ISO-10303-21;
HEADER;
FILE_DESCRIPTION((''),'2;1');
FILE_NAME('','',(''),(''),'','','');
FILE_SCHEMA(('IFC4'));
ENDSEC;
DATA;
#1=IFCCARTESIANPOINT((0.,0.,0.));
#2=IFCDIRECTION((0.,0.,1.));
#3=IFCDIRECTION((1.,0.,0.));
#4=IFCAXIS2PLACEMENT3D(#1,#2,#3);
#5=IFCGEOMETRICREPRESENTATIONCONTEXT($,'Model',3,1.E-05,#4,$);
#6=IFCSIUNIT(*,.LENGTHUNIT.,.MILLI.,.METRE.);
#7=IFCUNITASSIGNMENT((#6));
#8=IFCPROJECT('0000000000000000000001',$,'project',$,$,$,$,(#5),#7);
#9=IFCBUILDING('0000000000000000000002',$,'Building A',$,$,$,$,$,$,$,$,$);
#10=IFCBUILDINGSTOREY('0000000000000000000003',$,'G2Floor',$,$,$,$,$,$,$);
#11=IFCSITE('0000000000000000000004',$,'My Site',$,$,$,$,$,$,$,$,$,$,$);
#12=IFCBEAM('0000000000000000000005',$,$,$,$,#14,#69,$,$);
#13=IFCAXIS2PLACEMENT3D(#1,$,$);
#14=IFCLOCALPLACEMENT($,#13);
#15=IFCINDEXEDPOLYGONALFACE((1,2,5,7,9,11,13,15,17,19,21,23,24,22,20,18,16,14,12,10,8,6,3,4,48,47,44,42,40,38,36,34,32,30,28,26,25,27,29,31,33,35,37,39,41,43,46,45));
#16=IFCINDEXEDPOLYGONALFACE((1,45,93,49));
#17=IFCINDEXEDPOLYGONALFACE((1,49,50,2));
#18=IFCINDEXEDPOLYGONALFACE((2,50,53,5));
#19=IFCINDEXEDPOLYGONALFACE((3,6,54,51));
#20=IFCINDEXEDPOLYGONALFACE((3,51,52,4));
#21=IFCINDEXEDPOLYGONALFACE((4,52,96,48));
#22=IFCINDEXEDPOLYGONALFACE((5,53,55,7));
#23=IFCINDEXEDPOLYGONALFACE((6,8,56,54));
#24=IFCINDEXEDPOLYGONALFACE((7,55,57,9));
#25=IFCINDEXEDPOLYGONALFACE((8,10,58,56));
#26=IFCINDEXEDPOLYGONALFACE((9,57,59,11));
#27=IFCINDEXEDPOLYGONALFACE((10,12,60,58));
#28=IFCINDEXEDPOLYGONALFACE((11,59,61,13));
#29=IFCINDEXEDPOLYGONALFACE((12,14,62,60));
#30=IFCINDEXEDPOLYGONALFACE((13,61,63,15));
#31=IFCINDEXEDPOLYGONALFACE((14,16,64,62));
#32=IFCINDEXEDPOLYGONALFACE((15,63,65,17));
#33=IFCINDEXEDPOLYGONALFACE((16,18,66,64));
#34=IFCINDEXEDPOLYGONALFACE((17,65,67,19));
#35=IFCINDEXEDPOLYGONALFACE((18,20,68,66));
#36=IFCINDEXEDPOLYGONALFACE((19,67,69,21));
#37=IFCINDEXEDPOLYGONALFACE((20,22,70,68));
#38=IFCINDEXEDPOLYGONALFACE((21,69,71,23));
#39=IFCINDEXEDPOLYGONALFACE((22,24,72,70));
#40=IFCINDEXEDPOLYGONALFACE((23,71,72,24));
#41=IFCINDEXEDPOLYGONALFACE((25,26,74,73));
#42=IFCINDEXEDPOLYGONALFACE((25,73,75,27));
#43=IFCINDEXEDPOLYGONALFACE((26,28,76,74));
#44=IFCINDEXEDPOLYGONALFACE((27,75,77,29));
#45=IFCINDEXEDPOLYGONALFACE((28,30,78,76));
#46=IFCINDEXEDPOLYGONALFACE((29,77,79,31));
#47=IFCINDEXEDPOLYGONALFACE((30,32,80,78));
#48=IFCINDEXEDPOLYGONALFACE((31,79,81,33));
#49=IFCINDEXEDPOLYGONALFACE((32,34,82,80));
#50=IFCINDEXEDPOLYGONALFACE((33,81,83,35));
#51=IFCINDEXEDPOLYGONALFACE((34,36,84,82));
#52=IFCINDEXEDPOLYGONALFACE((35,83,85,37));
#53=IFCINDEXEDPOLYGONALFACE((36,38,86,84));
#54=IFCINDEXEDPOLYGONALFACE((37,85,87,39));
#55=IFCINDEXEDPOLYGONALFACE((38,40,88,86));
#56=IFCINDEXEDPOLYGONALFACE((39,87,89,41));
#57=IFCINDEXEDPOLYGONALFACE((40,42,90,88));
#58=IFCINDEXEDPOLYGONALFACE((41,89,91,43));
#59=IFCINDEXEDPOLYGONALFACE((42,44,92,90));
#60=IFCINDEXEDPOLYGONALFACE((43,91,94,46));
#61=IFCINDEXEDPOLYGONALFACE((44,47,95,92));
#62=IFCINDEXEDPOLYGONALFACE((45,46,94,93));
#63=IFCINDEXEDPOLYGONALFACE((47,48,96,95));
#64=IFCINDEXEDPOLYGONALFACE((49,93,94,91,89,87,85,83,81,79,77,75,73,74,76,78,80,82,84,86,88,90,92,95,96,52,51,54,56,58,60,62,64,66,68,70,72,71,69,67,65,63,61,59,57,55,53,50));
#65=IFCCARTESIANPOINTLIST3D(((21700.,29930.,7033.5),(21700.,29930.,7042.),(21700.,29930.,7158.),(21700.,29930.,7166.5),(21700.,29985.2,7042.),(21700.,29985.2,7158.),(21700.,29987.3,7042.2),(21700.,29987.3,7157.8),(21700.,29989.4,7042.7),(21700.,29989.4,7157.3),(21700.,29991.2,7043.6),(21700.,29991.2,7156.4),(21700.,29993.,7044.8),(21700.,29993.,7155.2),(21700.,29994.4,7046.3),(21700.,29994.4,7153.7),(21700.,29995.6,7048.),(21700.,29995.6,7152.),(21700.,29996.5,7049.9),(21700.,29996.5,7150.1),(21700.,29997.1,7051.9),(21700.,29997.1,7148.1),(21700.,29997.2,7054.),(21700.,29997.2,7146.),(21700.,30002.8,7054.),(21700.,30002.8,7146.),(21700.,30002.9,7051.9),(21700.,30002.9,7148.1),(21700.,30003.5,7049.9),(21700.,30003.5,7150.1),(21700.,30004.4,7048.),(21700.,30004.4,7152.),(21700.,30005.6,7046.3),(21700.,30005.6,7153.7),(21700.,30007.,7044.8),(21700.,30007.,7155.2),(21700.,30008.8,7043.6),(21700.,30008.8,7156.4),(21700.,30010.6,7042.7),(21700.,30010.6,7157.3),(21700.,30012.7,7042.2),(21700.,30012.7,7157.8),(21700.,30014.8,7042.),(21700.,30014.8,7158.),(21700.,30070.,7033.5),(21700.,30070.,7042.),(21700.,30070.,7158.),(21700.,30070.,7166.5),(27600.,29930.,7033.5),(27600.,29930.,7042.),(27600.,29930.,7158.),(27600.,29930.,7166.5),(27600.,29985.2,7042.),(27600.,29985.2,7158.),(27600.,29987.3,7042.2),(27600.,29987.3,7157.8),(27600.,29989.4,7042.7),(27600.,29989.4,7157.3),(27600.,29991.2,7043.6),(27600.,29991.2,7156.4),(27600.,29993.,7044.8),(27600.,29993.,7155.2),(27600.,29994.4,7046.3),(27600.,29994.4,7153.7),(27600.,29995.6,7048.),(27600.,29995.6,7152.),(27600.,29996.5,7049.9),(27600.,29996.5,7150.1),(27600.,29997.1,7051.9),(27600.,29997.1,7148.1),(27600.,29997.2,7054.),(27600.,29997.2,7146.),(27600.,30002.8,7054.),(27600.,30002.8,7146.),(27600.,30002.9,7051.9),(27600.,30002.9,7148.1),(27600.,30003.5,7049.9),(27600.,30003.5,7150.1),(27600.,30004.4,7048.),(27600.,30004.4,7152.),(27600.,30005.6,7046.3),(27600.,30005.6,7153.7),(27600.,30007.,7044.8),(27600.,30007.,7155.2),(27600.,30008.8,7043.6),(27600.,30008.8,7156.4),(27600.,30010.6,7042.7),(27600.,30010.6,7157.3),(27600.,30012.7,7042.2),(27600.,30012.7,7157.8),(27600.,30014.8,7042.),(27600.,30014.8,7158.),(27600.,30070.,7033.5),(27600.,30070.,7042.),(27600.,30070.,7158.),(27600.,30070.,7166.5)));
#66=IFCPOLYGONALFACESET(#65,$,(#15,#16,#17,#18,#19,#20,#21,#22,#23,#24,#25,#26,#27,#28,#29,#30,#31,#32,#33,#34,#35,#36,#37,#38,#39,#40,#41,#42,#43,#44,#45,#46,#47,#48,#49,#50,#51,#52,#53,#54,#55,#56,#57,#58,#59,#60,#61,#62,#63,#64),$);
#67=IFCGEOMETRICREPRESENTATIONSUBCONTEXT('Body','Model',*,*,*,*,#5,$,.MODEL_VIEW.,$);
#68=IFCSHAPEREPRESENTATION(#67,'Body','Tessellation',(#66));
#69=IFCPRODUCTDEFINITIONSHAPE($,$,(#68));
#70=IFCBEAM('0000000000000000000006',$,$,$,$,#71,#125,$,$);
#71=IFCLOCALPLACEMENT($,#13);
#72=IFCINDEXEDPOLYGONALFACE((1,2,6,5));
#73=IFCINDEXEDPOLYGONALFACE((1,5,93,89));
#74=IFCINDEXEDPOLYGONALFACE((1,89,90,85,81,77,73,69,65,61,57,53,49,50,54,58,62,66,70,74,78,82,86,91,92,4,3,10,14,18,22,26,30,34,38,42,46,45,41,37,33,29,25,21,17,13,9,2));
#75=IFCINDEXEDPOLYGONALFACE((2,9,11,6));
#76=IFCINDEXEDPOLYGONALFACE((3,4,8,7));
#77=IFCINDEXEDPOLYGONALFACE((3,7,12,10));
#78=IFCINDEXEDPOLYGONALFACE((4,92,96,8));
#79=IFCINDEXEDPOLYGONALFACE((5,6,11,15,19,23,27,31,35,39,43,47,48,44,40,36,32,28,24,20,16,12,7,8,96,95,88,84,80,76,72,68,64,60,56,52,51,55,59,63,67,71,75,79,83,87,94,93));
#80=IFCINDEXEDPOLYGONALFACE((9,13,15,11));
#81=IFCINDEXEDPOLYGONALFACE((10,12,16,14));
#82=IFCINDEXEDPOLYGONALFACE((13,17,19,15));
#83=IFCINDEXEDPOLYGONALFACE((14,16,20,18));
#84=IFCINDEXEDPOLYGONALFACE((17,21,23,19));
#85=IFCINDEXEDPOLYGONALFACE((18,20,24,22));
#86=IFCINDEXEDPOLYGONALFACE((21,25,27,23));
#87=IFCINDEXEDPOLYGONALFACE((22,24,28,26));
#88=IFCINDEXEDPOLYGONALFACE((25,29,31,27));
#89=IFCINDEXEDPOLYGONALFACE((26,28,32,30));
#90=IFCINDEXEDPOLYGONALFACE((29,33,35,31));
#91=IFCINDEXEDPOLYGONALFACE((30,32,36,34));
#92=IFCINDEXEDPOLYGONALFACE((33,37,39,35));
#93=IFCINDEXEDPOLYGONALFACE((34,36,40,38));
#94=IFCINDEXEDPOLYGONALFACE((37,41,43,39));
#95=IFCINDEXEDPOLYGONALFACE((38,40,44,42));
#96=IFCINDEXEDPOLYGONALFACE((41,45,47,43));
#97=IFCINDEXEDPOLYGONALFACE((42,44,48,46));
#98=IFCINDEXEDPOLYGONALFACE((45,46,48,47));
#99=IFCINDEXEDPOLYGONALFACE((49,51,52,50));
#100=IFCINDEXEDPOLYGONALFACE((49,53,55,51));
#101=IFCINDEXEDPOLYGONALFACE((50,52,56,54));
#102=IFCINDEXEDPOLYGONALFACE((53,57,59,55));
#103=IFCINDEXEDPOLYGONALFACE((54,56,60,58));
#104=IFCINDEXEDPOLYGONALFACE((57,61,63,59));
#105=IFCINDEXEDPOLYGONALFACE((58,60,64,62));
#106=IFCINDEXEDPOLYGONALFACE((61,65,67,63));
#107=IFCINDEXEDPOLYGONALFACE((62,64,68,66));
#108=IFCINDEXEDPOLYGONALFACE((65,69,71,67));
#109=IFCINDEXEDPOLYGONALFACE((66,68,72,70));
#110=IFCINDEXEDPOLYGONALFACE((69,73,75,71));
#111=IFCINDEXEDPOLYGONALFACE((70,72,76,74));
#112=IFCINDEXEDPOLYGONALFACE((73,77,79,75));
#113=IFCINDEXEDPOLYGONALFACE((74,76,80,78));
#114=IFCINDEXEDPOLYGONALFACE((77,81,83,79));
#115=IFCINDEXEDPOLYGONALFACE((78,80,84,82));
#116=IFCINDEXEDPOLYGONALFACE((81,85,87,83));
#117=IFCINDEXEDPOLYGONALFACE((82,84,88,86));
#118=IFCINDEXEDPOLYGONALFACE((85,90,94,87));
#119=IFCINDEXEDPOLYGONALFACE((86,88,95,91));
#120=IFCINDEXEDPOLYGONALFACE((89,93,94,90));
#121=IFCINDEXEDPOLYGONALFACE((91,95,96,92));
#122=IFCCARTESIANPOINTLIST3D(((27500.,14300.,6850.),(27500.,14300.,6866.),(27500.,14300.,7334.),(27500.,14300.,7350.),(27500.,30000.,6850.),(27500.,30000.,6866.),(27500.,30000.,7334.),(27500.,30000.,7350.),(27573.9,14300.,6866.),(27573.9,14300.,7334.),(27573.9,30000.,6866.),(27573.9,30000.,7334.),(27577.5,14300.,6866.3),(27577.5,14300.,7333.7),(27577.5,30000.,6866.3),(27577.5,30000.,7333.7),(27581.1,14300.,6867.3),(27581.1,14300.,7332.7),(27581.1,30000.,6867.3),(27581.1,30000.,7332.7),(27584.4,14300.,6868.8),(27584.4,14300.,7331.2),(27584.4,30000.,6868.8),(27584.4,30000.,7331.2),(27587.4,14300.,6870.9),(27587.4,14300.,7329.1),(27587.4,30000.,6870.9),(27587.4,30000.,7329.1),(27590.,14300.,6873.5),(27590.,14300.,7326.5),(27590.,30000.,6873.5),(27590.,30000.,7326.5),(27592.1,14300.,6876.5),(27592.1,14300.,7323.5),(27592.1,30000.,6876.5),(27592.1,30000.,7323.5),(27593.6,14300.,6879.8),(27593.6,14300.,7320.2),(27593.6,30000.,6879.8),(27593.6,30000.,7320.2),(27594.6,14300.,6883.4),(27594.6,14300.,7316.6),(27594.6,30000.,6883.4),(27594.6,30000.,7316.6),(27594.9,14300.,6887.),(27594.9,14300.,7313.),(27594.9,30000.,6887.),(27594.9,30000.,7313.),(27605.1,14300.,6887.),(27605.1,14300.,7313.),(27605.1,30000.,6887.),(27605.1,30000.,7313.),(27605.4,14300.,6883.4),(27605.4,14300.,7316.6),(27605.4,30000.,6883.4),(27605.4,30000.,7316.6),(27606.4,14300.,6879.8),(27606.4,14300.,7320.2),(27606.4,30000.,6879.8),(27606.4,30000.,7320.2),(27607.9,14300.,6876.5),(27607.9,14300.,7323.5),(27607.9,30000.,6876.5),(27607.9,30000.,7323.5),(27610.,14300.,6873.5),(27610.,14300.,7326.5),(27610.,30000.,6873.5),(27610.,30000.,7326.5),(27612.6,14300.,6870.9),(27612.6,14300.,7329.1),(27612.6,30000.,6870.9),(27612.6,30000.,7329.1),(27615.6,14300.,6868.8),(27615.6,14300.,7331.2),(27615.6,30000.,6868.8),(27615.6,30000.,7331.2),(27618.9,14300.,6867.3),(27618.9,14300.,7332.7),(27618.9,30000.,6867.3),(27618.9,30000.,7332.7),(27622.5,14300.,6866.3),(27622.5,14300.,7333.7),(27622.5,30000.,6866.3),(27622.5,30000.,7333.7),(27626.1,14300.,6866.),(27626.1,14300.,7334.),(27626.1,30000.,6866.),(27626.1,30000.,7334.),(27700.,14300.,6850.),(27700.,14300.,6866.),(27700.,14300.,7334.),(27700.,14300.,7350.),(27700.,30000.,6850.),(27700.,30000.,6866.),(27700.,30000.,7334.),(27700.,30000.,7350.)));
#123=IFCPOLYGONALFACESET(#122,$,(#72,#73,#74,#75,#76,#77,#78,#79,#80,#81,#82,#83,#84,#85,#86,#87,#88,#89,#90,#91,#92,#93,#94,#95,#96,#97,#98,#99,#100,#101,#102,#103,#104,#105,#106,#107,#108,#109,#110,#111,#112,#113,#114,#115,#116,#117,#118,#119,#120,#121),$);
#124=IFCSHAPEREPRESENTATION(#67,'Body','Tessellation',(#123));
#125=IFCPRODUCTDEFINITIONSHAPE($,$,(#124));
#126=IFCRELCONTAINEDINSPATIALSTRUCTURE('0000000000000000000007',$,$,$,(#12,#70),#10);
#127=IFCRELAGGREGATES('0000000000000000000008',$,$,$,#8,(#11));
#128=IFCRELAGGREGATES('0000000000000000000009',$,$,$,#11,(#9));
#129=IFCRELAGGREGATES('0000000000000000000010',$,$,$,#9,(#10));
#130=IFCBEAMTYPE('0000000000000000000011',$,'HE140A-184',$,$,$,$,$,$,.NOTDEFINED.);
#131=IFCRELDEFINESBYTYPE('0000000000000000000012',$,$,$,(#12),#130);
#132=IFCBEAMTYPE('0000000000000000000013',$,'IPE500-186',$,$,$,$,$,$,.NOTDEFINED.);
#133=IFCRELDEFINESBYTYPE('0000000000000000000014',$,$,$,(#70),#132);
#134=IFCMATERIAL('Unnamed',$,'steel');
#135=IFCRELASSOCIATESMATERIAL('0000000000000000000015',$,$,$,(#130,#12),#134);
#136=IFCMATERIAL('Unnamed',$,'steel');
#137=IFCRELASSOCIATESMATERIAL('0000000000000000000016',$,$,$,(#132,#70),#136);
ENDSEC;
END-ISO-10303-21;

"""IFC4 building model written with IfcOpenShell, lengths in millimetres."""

from ifc_helpers import new_model, si_unit, frame, origin_with_axes, place, context, subcontext, project, spatial, polyline, outline, extrude, material, material_profile, profile_set, profile_usage, type_object, element, save


model = new_model("IFC4")

# Units and contexts
model_context = context("Model", 3, precision=1e-05, world=origin_with_axes())
body_context = subcontext(model_context, "Body", "Model", "MODEL_VIEW")
ifc_project = project(units=[si_unit("LENGTHUNIT", "METRE", prefix="MILLI")], contexts=[model_context])

# Site, building, storey
site = spatial("IfcSite", under=ifc_project, Name="My Site")
building = spatial("IfcBuilding", under=site, Name="Building A")
storey = spatial("IfcBuildingStorey", under=building, Name="G2Floor")

# Beams
ifc_material_1 = material(Name="Unnamed", Category="steel")
ifc_material_profile_1 = material_profile(ifc_material_1, outline(polyline([(70.0, -66.5), (70.0, -58.0), (70.0, -58.0), (14.8, -58.0), (14.8, -58.0), (12.7, -57.8), (12.7, -57.8), (10.6, -57.3), (10.6, -57.3), (8.8, -56.4), (8.8, -56.4), (7.0, -55.2), (7.0, -55.2), (5.6, -53.7), (5.6, -53.7), (4.4, -52.0), (4.4, -52.0), (3.5, -50.1), (3.5, -50.1), (2.9, -48.1), (2.9, -48.1), (2.8, -46.0), (2.8, -46.0), (2.8, 46.0), (2.8, 46.0), (2.9, 48.1), (2.9, 48.1), (3.5, 50.1), (3.5, 50.1), (4.4, 52.0), (4.4, 52.0), (5.6, 53.7), (5.6, 53.7), (7.0, 55.2), (7.0, 55.2), (8.8, 56.4), (8.8, 56.4), (10.6, 57.3), (10.6, 57.3), (12.7, 57.8), (12.7, 57.8), (14.8, 58.0), (14.8, 58.0), (70.0, 58.0), (70.0, 58.0), (70.0, 66.5), (70.0, 66.5), (-70.0, 66.5), (-70.0, 66.5), (-70.0, 58.0), (-70.0, 58.0), (-14.8, 58.0), (-14.8, 58.0), (-12.7, 57.8), (-12.7, 57.8), (-10.6, 57.3), (-10.6, 57.3), (-8.8, 56.4), (-8.8, 56.4), (-7.0, 55.2), (-7.0, 55.2), (-5.6, 53.7), (-5.6, 53.7), (-4.4, 52.0), (-4.4, 52.0), (-3.5, 50.1), (-3.5, 50.1), (-2.9, 48.1), (-2.9, 48.1), (-2.8, 46.0), (-2.8, 46.0), (-2.8, -46.0), (-2.8, -46.0), (-2.9, -48.1), (-2.9, -48.1), (-3.5, -50.1), (-3.5, -50.1), (-4.4, -52.0), (-4.4, -52.0), (-5.6, -53.7), (-5.6, -53.7), (-7.0, -55.2), (-7.0, -55.2), (-8.8, -56.4), (-8.8, -56.4), (-10.6, -57.3), (-10.6, -57.3), (-12.7, -57.8), (-12.7, -57.8), (-14.8, -58.0), (-14.8, -58.0), (-70.0, -58.0), (-70.0, -58.0), (-70.0, -66.5), (-70.0, -66.5), (70.0, -66.5)])))
ifc_profile_set_1 = profile_set([ifc_material_profile_1], Name="HE140A-184")
ifc_profile_usage_1 = profile_usage(ifc_profile_set_1)
beam_type_1 = type_object("IfcBeamType", Name="HE140A-184", PredefinedType="NOTDEFINED", material=ifc_profile_set_1)
beam_1_placement = place(None, frame((21700.0, 30000.0, 7100.0), z_axis=(1.0, 0.0, 0.0), x_axis=(0.0, -1.0, 0.0)))
element("IfcBeam", 1, at=beam_1_placement, inside=storey, type_object=beam_type_1, material=ifc_profile_usage_1, context=body_context, shape_type="SweptSolid", body=[
    extrude(outline(polyline([(70.0, -66.5), (70.0, -58.0), (70.0, -58.0), (14.8, -58.0), (14.8, -58.0), (12.7, -57.8), (12.7, -57.8), (10.6, -57.3), (10.6, -57.3), (8.8, -56.4), (8.8, -56.4), (7.0, -55.2), (7.0, -55.2), (5.6, -53.7), (5.6, -53.7), (4.4, -52.0), (4.4, -52.0), (3.5, -50.1), (3.5, -50.1), (2.9, -48.1), (2.9, -48.1), (2.8, -46.0), (2.8, -46.0), (2.8, 46.0), (2.8, 46.0), (2.9, 48.1), (2.9, 48.1), (3.5, 50.1), (3.5, 50.1), (4.4, 52.0), (4.4, 52.0), (5.6, 53.7), (5.6, 53.7), (7.0, 55.2), (7.0, 55.2), (8.8, 56.4), (8.8, 56.4), (10.6, 57.3), (10.6, 57.3), (12.7, 57.8), (12.7, 57.8), (14.8, 58.0), (14.8, 58.0), (70.0, 58.0), (70.0, 58.0), (70.0, 66.5), (70.0, 66.5), (-70.0, 66.5), (-70.0, 66.5), (-70.0, 58.0), (-70.0, 58.0), (-14.8, 58.0), (-14.8, 58.0), (-12.7, 57.8), (-12.7, 57.8), (-10.6, 57.3), (-10.6, 57.3), (-8.8, 56.4), (-8.8, 56.4), (-7.0, 55.2), (-7.0, 55.2), (-5.6, 53.7), (-5.6, 53.7), (-4.4, 52.0), (-4.4, 52.0), (-3.5, 50.1), (-3.5, 50.1), (-2.9, 48.1), (-2.9, 48.1), (-2.8, 46.0), (-2.8, 46.0), (-2.8, -46.0), (-2.8, -46.0), (-2.9, -48.1), (-2.9, -48.1), (-3.5, -50.1), (-3.5, -50.1), (-4.4, -52.0), (-4.4, -52.0), (-5.6, -53.7), (-5.6, -53.7), (-7.0, -55.2), (-7.0, -55.2), (-8.8, -56.4), (-8.8, -56.4), (-10.6, -57.3), (-10.6, -57.3), (-12.7, -57.8), (-12.7, -57.8), (-14.8, -58.0), (-14.8, -58.0), (-70.0, -58.0), (-70.0, -58.0), (-70.0, -66.5), (-70.0, -66.5), (70.0, -66.5)])), origin_with_axes(), (0.0, 0.0, 1.0), 5900.0),
])
ifc_material_2 = material(Name="Unnamed", Category="steel")
ifc_material_profile_2 = material_profile(ifc_material_2, outline(polyline([(100.0, -250.0), (100.0, -234.0), (100.0, -234.0), (26.1, -234.0), (26.1, -234.0), (22.5, -233.7), (22.5, -233.7), (18.9, -232.7), (18.9, -232.7), (15.6, -231.2), (15.6, -231.2), (12.6, -229.1), (12.6, -229.1), (10.0, -226.5), (10.0, -226.5), (7.9, -223.5), (7.9, -223.5), (6.4, -220.2), (6.4, -220.2), (5.4, -216.6), (5.4, -216.6), (5.1, -213.0), (5.1, -213.0), (5.1, 213.0), (5.1, 213.0), (5.4, 216.6), (5.4, 216.6), (6.4, 220.2), (6.4, 220.2), (7.9, 223.5), (7.9, 223.5), (10.0, 226.5), (10.0, 226.5), (12.6, 229.1), (12.6, 229.1), (15.6, 231.2), (15.6, 231.2), (18.9, 232.7), (18.9, 232.7), (22.5, 233.7), (22.5, 233.7), (26.1, 234.0), (26.1, 234.0), (100.0, 234.0), (100.0, 234.0), (100.0, 250.0), (100.0, 250.0), (-100.0, 250.0), (-100.0, 250.0), (-100.0, 234.0), (-100.0, 234.0), (-26.1, 234.0), (-26.1, 234.0), (-22.5, 233.7), (-22.5, 233.7), (-18.9, 232.7), (-18.9, 232.7), (-15.6, 231.2), (-15.6, 231.2), (-12.6, 229.1), (-12.6, 229.1), (-10.0, 226.5), (-10.0, 226.5), (-7.9, 223.5), (-7.9, 223.5), (-6.4, 220.2), (-6.4, 220.2), (-5.4, 216.6), (-5.4, 216.6), (-5.1, 213.0), (-5.1, 213.0), (-5.1, -213.0), (-5.1, -213.0), (-5.4, -216.6), (-5.4, -216.6), (-6.4, -220.2), (-6.4, -220.2), (-7.9, -223.5), (-7.9, -223.5), (-10.0, -226.5), (-10.0, -226.5), (-12.6, -229.1), (-12.6, -229.1), (-15.6, -231.2), (-15.6, -231.2), (-18.9, -232.7), (-18.9, -232.7), (-22.5, -233.7), (-22.5, -233.7), (-26.1, -234.0), (-26.1, -234.0), (-100.0, -234.0), (-100.0, -234.0), (-100.0, -250.0), (-100.0, -250.0), (100.0, -250.0)])))
ifc_profile_set_2 = profile_set([ifc_material_profile_2], Name="IPE500-186")
ifc_profile_usage_2 = profile_usage(ifc_profile_set_2)
beam_type_2 = type_object("IfcBeamType", Name="IPE500-186", PredefinedType="NOTDEFINED", material=ifc_profile_set_2)
beam_2_placement = place(None, frame((27600.0, 14300.0, 7100.0), z_axis=(0.0, 1.0, 0.0), x_axis=(1.0, 0.0, 0.0)))
element("IfcBeam", 2, at=beam_2_placement, inside=storey, type_object=beam_type_2, material=ifc_profile_usage_2, context=body_context, shape_type="SweptSolid", body=[
    extrude(outline(polyline([(100.0, -250.0), (100.0, -234.0), (100.0, -234.0), (26.1, -234.0), (26.1, -234.0), (22.5, -233.7), (22.5, -233.7), (18.9, -232.7), (18.9, -232.7), (15.6, -231.2), (15.6, -231.2), (12.6, -229.1), (12.6, -229.1), (10.0, -226.5), (10.0, -226.5), (7.9, -223.5), (7.9, -223.5), (6.4, -220.2), (6.4, -220.2), (5.4, -216.6), (5.4, -216.6), (5.1, -213.0), (5.1, -213.0), (5.1, 213.0), (5.1, 213.0), (5.4, 216.6), (5.4, 216.6), (6.4, 220.2), (6.4, 220.2), (7.9, 223.5), (7.9, 223.5), (10.0, 226.5), (10.0, 226.5), (12.6, 229.1), (12.6, 229.1), (15.6, 231.2), (15.6, 231.2), (18.9, 232.7), (18.9, 232.7), (22.5, 233.7), (22.5, 233.7), (26.1, 234.0), (26.1, 234.0), (100.0, 234.0), (100.0, 234.0), (100.0, 250.0), (100.0, 250.0), (-100.0, 250.0), (-100.0, 250.0), (-100.0, 234.0), (-100.0, 234.0), (-26.1, 234.0), (-26.1, 234.0), (-22.5, 233.7), (-22.5, 233.7), (-18.9, 232.7), (-18.9, 232.7), (-15.6, 231.2), (-15.6, 231.2), (-12.6, 229.1), (-12.6, 229.1), (-10.0, 226.5), (-10.0, 226.5), (-7.9, 223.5), (-7.9, 223.5), (-6.4, 220.2), (-6.4, 220.2), (-5.4, 216.6), (-5.4, 216.6), (-5.1, 213.0), (-5.1, 213.0), (-5.1, -213.0), (-5.1, -213.0), (-5.4, -216.6), (-5.4, -216.6), (-6.4, -220.2), (-6.4, -220.2), (-7.9, -223.5), (-7.9, -223.5), (-10.0, -226.5), (-10.0, -226.5), (-12.6, -229.1), (-12.6, -229.1), (-15.6, -231.2), (-15.6, -231.2), (-18.9, -232.7), (-18.9, -232.7), (-22.5, -233.7), (-22.5, -233.7), (-26.1, -234.0), (-26.1, -234.0), (-100.0, -234.0), (-100.0, -234.0), (-100.0, -250.0), (-100.0, -250.0), (100.0, -250.0)])), origin_with_axes(), (0.0, 0.0, 1.0), 15700.0),
])

save(model, "model.ifc")
